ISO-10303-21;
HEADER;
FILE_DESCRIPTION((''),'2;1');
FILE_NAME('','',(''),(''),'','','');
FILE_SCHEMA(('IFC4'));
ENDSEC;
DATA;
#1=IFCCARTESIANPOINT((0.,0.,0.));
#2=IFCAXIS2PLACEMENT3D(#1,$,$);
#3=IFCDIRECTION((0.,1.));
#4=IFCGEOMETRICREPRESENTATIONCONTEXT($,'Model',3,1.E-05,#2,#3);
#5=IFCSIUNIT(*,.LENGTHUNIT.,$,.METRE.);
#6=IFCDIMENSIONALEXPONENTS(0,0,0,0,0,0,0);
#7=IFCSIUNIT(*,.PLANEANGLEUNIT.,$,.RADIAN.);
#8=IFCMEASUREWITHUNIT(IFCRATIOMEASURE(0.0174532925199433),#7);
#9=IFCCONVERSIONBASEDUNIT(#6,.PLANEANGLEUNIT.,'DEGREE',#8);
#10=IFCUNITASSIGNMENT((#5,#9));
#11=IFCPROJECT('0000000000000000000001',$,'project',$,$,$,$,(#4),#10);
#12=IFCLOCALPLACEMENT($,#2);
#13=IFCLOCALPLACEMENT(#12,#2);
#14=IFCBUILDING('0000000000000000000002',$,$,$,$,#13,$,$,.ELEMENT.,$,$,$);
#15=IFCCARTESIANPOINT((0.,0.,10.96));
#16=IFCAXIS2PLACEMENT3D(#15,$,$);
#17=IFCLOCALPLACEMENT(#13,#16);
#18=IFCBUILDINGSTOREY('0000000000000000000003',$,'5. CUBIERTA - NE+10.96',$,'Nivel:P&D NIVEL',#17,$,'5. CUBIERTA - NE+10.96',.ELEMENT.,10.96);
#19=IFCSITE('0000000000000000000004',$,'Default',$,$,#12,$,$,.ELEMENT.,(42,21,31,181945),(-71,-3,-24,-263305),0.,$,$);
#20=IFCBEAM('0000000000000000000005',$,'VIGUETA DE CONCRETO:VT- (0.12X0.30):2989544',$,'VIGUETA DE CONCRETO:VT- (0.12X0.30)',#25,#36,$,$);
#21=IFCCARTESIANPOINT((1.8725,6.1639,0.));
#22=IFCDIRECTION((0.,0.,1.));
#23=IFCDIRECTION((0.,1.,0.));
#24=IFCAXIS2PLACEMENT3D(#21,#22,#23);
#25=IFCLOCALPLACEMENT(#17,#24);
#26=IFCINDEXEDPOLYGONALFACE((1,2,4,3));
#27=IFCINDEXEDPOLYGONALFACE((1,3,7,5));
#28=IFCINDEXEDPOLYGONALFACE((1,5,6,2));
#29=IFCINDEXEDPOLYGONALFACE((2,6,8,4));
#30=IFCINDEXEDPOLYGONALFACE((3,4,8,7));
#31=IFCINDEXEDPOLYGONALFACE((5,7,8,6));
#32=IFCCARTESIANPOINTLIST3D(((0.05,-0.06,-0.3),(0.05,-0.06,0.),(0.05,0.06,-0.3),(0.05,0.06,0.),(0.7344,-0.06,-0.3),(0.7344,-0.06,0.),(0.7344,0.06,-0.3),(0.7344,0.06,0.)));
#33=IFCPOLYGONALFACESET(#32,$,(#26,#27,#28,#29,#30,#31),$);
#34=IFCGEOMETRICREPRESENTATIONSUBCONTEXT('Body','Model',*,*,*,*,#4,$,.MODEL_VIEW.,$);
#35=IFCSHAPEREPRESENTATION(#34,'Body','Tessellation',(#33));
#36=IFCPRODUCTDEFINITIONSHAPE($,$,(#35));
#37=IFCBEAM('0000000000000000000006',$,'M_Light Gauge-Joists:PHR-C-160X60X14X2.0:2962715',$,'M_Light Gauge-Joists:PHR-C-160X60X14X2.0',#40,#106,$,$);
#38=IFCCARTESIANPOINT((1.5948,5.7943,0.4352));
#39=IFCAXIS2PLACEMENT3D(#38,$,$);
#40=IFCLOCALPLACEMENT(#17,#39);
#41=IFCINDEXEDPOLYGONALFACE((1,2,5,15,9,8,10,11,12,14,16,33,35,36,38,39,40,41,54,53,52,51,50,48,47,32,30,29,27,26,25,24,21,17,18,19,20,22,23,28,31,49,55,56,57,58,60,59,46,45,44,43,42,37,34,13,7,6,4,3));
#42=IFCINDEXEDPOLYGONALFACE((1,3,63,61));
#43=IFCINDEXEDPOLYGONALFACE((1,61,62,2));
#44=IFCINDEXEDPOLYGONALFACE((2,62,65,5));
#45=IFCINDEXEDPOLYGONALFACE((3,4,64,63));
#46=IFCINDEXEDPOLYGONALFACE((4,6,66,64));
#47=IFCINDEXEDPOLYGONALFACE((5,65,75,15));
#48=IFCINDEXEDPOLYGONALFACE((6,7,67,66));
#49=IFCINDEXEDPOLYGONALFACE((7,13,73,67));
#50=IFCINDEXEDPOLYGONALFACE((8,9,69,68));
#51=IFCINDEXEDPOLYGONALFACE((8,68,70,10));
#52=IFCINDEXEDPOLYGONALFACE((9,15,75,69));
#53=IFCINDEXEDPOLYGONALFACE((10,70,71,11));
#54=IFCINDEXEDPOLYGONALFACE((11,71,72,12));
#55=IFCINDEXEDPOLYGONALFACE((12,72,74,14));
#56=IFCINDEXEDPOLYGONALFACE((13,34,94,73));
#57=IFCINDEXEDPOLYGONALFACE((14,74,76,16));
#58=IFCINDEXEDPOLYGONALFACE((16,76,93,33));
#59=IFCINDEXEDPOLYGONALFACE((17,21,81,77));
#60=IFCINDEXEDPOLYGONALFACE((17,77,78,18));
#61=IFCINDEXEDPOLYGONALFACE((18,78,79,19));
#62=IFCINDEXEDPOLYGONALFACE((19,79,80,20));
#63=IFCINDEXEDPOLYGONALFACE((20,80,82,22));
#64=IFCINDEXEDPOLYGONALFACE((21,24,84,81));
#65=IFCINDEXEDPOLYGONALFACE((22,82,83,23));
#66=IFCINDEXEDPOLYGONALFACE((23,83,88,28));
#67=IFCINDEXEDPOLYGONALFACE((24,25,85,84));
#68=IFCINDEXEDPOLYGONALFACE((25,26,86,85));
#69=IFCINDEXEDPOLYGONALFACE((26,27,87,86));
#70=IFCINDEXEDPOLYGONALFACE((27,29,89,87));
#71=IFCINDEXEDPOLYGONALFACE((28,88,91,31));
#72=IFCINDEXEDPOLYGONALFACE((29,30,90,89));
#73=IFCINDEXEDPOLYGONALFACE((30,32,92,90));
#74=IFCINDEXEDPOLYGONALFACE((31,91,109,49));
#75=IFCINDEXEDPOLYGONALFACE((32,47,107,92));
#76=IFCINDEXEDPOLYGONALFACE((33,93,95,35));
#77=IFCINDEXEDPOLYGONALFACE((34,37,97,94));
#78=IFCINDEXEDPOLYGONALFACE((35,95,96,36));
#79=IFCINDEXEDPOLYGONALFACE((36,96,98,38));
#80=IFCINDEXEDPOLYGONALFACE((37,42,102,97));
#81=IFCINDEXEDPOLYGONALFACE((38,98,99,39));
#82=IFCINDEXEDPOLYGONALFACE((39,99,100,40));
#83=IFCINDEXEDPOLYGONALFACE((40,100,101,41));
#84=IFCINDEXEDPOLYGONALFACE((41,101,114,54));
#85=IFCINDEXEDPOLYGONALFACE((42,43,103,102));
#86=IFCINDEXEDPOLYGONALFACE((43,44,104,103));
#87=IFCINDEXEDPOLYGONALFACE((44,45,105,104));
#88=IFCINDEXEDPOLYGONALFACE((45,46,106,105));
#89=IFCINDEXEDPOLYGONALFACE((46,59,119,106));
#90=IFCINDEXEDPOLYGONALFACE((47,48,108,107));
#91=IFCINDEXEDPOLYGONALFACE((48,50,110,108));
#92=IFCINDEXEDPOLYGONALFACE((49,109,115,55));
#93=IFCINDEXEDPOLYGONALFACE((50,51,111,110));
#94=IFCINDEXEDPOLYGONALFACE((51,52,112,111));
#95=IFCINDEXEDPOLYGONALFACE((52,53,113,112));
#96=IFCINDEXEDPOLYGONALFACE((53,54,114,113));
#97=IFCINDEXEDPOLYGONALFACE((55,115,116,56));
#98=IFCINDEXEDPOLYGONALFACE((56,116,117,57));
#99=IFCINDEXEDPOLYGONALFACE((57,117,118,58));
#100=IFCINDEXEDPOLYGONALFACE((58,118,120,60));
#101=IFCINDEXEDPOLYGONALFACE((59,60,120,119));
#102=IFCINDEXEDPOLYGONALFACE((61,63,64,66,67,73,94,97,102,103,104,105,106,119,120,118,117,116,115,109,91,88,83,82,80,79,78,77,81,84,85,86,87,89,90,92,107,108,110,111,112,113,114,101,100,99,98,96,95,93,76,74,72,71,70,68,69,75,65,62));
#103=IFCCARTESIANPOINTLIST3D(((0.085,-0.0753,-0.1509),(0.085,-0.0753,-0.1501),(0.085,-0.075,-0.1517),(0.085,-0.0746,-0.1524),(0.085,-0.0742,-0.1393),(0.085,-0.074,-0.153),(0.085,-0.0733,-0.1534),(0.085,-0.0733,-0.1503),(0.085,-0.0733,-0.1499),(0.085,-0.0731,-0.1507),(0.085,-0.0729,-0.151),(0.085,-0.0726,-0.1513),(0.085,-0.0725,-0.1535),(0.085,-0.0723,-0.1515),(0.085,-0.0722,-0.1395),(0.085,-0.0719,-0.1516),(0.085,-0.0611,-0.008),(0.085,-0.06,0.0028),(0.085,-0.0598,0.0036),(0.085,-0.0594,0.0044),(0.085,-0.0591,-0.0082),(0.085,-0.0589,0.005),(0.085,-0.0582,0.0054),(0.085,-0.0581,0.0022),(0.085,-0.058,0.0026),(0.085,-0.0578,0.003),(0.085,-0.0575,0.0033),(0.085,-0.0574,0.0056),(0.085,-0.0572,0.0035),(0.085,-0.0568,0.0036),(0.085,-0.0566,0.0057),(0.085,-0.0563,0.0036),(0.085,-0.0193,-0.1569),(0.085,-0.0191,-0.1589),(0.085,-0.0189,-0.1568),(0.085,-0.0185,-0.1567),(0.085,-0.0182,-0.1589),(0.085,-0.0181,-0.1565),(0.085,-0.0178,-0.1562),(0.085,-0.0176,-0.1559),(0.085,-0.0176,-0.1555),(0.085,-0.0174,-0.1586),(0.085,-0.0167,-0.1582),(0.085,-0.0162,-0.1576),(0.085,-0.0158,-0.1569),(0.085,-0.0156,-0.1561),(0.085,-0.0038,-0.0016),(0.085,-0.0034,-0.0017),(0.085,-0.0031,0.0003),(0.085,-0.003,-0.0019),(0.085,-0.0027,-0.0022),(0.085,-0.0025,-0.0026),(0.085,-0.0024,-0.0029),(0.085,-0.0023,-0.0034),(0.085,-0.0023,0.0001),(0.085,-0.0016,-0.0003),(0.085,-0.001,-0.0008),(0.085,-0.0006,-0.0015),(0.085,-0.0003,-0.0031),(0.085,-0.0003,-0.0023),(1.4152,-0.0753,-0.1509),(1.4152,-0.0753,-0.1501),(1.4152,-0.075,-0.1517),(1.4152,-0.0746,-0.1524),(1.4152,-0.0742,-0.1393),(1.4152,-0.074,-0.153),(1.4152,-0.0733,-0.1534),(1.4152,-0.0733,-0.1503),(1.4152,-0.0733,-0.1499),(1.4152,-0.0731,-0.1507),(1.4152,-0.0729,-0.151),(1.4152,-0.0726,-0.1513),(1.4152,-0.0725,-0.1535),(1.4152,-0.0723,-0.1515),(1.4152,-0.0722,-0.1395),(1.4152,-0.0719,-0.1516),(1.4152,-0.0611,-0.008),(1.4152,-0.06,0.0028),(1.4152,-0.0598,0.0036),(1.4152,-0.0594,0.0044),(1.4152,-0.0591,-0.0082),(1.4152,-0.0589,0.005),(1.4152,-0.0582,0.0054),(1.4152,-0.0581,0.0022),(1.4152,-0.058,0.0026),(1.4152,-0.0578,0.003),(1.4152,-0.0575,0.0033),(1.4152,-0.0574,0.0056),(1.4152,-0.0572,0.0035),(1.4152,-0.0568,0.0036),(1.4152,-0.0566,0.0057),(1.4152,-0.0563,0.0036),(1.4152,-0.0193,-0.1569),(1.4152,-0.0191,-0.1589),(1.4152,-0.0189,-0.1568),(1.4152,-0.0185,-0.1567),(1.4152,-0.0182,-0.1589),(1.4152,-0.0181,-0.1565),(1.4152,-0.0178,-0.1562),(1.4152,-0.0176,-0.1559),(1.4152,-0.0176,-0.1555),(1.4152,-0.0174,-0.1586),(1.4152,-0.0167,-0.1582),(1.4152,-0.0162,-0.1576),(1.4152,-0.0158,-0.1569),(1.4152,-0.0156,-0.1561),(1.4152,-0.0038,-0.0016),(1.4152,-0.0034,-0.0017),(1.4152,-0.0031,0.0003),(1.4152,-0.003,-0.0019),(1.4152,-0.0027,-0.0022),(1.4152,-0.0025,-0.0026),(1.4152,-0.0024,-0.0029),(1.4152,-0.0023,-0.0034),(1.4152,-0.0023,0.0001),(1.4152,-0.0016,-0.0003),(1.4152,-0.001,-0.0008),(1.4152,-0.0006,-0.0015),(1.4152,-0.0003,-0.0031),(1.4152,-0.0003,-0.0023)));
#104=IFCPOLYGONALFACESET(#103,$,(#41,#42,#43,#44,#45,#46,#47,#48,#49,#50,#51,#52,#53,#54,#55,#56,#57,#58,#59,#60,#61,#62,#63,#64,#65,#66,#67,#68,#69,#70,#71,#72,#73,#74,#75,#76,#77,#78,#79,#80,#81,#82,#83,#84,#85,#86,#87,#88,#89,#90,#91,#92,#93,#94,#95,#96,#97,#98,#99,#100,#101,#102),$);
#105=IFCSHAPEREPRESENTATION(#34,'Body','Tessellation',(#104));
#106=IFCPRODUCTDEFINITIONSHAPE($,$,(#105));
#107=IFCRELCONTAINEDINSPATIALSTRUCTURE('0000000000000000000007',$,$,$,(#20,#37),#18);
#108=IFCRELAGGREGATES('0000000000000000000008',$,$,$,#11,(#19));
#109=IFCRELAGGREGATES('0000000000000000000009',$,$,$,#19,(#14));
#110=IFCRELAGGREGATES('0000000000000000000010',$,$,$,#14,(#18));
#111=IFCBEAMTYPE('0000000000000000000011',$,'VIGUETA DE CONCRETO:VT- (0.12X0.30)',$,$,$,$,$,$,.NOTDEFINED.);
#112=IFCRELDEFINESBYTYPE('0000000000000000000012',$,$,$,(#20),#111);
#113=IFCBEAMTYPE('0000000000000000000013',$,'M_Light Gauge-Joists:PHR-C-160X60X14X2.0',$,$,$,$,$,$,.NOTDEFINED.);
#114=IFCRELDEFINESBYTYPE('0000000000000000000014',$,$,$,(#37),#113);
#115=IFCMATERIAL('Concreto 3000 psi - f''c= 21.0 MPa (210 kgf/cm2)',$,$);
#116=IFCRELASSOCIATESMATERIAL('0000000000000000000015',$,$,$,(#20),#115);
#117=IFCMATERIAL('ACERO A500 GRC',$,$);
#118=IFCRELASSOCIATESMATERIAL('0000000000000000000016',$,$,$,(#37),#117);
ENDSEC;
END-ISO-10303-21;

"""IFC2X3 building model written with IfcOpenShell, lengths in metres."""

from ifc_helpers import new_model, entity, si_unit, converted_unit, direction, frame, frame_2d, origin, place, context, subcontext, project, spatial, polyline, circle_curve, parameter, trimmed, segment, composite_curve, rectangle, outline, extrude, material, type_object, element, save


model = new_model("IFC2X3")

# Units and contexts
model_context = context("Model", 3, precision=1e-05, world=origin(), true_north=direction((0.0, 1.0)))
body_context = subcontext(model_context, "Body", "Model", "MODEL_VIEW")
ifc_project = project(units=[si_unit("LENGTHUNIT", "METRE"), converted_unit("PLANEANGLEUNIT", "DEGREE", entity("IfcRatioMeasure", 0.0174532925199433), si_unit("PLANEANGLEUNIT", "RADIAN"), dimensions=[0, 0, 0, 0, 0, 0, 0])], contexts=[model_context])

# Site, building, storey
site_placement = place(None, origin())
site = spatial("IfcSite", under=ifc_project, at=site_placement, Name="Default", CompositionType="ELEMENT", RefLatitude=(42, 21, 31, 181945), RefLongitude=(-71, -3, -24, -263305), RefElevation=0.0)
building_placement = place(site_placement, origin())
building = spatial("IfcBuilding", under=site, at=building_placement, CompositionType="ELEMENT")
storey_placement = place(building_placement, frame((0.0, 0.0, 10.96)))
storey = spatial("IfcBuildingStorey", under=building, at=storey_placement, Name="5. CUBIERTA - NE+10.96", ObjectType="Nivel:P&D NIVEL", LongName="5. CUBIERTA - NE+10.96", CompositionType="ELEMENT", Elevation=10.96)

# Beams
ifc_material_1 = material(Name="Concreto 3000 psi - f'c= 21.0 MPa (210 kgf/cm2)")
beam_type_1 = type_object("IfcBeamType", Name="VIGUETA DE CONCRETO:VT- (0.12X0.30)", PredefinedType="NOTDEFINED")
beam_1_placement = place(storey_placement, frame((1.8725, 6.1639, 0.0), z_axis=(0.0, 0.0, 1.0), x_axis=(0.0, 1.0, 0.0)))
element("IfcBeam", 1, at=beam_1_placement, inside=storey, type_object=beam_type_1, material=ifc_material_1, Name="VIGUETA DE CONCRETO:VT- (0.12X0.30):2989544", ObjectType="VIGUETA DE CONCRETO:VT- (0.12X0.30)", context=body_context, shape_type="SweptSolid", body=[
    extrude(rectangle(XDim=0.3, YDim=0.12, at=frame_2d((0.0, 0.0), x_axis=(1.0, 0.0))), frame((0.05, 0.0, -0.15), z_axis=(1.0, 0.0, 0.0), x_axis=(0.0, 0.0, -1.0)), (0.0, 0.0, 1.0), 0.6844),
])
ifc_material_2 = material(Name="ACERO A500 GRC")
beam_type_2 = type_object("IfcBeamType", Name="M_Light Gauge-Joists:PHR-C-160X60X14X2.0", PredefinedType="NOTDEFINED")
beam_2_placement = place(storey_placement, frame((1.5948, 5.7943, 0.4352)))
element("IfcBeam", 2, at=beam_2_placement, inside=storey, type_object=beam_type_2, material=ifc_material_2, Name="M_Light Gauge-Joists:PHR-C-160X60X14X2.0:2962715", ObjectType="M_Light Gauge-Joists:PHR-C-160X60X14X2.0", context=body_context, shape_type="SweptSolid", body=[
    extrude(outline(composite_curve([segment(polyline([(-0.0768, -0.0358), (0.0768, -0.0358)]), True, "CONTINUOUS"), segment(trimmed(circle_curve(frame_2d((0.0768, -0.0326), x_axis=(0.0, -1.0)), 0.0032), [parameter(0.0)], [parameter(90.0)], True, "PARAMETER"), True, "CONTINUOUS"), segment(polyline([(0.08, -0.0326), (0.08, 0.021)]), True, "CONTINUOUS"), segment(trimmed(circle_curve(frame_2d((0.0768, 0.021), x_axis=(1.0, 0.0)), 0.0032), [parameter(0.0)], [parameter(90.0)], True, "PARAMETER"), True, "CONTINUOUS"), segment(polyline([(0.0768, 0.0242), (0.066, 0.0242)]), True, "CONTINUOUS"), segment(polyline([(0.066, 0.0242), (0.066, 0.0222)]), True, "CONTINUOUS"), segment(polyline([(0.066, 0.0222), (0.0764, 0.0222)]), True, "CONTINUOUS"), segment(trimmed(circle_curve(frame_2d((0.0764, 0.0206), x_axis=(0.0, 1.0)), 0.0016), [parameter(270.0)], [parameter(0.0)], True, "PARAMETER"), False, "CONTINUOUS"), segment(polyline([(0.078, 0.0206), (0.078, -0.0322)]), True, "CONTINUOUS"), segment(trimmed(circle_curve(frame_2d((0.0764, -0.0322), x_axis=(1.0, 0.0)), 0.0016), [parameter(270.0)], [parameter(0.0)], True, "PARAMETER"), False, "CONTINUOUS"), segment(polyline([(0.0764, -0.0338), (-0.0764, -0.0338)]), True, "CONTINUOUS"), segment(trimmed(circle_curve(frame_2d((-0.0764, -0.0322), x_axis=(0.0, -1.0)), 0.0016), [parameter(270.0)], [parameter(0.0)], True, "PARAMETER"), False, "CONTINUOUS"), segment(polyline([(-0.078, -0.0322), (-0.078, 0.0206)]), True, "CONTINUOUS"), segment(trimmed(circle_curve(frame_2d((-0.0764, 0.0206), x_axis=(-1.0, 0.0)), 0.0016), [parameter(270.0)], [parameter(0.0)], True, "PARAMETER"), False, "CONTINUOUS"), segment(polyline([(-0.0764, 0.0222), (-0.066, 0.0222)]), True, "CONTINUOUS"), segment(polyline([(-0.066, 0.0222), (-0.066, 0.0242)]), True, "CONTINUOUS"), segment(polyline([(-0.066, 0.0242), (-0.0768, 0.0242)]), True, "CONTINUOUS"), segment(trimmed(circle_curve(frame_2d((-0.0768, 0.021), x_axis=(0.0, 1.0)), 0.0032), [parameter(0.0)], [parameter(90.0)], True, "PARAMETER"), True, "CONTINUOUS"), segment(polyline([(-0.08, 0.021), (-0.08, -0.0326)]), True, "CONTINUOUS"), segment(trimmed(circle_curve(frame_2d((-0.0768, -0.0326), x_axis=(-1.0, 0.0)), 0.0032), [parameter(0.0)], [parameter(90.0)], True, "PARAMETER"), True, "CONTINUOUS")], self_intersect=False)), frame((0.085, -0.0436, -0.076), z_axis=(1.0, 0.0, 0.0), x_axis=(0.0, 0.099504, 0.995037)), (0.0, 0.0, 1.0), 1.3302),
])

save(model, "model.ifc")
